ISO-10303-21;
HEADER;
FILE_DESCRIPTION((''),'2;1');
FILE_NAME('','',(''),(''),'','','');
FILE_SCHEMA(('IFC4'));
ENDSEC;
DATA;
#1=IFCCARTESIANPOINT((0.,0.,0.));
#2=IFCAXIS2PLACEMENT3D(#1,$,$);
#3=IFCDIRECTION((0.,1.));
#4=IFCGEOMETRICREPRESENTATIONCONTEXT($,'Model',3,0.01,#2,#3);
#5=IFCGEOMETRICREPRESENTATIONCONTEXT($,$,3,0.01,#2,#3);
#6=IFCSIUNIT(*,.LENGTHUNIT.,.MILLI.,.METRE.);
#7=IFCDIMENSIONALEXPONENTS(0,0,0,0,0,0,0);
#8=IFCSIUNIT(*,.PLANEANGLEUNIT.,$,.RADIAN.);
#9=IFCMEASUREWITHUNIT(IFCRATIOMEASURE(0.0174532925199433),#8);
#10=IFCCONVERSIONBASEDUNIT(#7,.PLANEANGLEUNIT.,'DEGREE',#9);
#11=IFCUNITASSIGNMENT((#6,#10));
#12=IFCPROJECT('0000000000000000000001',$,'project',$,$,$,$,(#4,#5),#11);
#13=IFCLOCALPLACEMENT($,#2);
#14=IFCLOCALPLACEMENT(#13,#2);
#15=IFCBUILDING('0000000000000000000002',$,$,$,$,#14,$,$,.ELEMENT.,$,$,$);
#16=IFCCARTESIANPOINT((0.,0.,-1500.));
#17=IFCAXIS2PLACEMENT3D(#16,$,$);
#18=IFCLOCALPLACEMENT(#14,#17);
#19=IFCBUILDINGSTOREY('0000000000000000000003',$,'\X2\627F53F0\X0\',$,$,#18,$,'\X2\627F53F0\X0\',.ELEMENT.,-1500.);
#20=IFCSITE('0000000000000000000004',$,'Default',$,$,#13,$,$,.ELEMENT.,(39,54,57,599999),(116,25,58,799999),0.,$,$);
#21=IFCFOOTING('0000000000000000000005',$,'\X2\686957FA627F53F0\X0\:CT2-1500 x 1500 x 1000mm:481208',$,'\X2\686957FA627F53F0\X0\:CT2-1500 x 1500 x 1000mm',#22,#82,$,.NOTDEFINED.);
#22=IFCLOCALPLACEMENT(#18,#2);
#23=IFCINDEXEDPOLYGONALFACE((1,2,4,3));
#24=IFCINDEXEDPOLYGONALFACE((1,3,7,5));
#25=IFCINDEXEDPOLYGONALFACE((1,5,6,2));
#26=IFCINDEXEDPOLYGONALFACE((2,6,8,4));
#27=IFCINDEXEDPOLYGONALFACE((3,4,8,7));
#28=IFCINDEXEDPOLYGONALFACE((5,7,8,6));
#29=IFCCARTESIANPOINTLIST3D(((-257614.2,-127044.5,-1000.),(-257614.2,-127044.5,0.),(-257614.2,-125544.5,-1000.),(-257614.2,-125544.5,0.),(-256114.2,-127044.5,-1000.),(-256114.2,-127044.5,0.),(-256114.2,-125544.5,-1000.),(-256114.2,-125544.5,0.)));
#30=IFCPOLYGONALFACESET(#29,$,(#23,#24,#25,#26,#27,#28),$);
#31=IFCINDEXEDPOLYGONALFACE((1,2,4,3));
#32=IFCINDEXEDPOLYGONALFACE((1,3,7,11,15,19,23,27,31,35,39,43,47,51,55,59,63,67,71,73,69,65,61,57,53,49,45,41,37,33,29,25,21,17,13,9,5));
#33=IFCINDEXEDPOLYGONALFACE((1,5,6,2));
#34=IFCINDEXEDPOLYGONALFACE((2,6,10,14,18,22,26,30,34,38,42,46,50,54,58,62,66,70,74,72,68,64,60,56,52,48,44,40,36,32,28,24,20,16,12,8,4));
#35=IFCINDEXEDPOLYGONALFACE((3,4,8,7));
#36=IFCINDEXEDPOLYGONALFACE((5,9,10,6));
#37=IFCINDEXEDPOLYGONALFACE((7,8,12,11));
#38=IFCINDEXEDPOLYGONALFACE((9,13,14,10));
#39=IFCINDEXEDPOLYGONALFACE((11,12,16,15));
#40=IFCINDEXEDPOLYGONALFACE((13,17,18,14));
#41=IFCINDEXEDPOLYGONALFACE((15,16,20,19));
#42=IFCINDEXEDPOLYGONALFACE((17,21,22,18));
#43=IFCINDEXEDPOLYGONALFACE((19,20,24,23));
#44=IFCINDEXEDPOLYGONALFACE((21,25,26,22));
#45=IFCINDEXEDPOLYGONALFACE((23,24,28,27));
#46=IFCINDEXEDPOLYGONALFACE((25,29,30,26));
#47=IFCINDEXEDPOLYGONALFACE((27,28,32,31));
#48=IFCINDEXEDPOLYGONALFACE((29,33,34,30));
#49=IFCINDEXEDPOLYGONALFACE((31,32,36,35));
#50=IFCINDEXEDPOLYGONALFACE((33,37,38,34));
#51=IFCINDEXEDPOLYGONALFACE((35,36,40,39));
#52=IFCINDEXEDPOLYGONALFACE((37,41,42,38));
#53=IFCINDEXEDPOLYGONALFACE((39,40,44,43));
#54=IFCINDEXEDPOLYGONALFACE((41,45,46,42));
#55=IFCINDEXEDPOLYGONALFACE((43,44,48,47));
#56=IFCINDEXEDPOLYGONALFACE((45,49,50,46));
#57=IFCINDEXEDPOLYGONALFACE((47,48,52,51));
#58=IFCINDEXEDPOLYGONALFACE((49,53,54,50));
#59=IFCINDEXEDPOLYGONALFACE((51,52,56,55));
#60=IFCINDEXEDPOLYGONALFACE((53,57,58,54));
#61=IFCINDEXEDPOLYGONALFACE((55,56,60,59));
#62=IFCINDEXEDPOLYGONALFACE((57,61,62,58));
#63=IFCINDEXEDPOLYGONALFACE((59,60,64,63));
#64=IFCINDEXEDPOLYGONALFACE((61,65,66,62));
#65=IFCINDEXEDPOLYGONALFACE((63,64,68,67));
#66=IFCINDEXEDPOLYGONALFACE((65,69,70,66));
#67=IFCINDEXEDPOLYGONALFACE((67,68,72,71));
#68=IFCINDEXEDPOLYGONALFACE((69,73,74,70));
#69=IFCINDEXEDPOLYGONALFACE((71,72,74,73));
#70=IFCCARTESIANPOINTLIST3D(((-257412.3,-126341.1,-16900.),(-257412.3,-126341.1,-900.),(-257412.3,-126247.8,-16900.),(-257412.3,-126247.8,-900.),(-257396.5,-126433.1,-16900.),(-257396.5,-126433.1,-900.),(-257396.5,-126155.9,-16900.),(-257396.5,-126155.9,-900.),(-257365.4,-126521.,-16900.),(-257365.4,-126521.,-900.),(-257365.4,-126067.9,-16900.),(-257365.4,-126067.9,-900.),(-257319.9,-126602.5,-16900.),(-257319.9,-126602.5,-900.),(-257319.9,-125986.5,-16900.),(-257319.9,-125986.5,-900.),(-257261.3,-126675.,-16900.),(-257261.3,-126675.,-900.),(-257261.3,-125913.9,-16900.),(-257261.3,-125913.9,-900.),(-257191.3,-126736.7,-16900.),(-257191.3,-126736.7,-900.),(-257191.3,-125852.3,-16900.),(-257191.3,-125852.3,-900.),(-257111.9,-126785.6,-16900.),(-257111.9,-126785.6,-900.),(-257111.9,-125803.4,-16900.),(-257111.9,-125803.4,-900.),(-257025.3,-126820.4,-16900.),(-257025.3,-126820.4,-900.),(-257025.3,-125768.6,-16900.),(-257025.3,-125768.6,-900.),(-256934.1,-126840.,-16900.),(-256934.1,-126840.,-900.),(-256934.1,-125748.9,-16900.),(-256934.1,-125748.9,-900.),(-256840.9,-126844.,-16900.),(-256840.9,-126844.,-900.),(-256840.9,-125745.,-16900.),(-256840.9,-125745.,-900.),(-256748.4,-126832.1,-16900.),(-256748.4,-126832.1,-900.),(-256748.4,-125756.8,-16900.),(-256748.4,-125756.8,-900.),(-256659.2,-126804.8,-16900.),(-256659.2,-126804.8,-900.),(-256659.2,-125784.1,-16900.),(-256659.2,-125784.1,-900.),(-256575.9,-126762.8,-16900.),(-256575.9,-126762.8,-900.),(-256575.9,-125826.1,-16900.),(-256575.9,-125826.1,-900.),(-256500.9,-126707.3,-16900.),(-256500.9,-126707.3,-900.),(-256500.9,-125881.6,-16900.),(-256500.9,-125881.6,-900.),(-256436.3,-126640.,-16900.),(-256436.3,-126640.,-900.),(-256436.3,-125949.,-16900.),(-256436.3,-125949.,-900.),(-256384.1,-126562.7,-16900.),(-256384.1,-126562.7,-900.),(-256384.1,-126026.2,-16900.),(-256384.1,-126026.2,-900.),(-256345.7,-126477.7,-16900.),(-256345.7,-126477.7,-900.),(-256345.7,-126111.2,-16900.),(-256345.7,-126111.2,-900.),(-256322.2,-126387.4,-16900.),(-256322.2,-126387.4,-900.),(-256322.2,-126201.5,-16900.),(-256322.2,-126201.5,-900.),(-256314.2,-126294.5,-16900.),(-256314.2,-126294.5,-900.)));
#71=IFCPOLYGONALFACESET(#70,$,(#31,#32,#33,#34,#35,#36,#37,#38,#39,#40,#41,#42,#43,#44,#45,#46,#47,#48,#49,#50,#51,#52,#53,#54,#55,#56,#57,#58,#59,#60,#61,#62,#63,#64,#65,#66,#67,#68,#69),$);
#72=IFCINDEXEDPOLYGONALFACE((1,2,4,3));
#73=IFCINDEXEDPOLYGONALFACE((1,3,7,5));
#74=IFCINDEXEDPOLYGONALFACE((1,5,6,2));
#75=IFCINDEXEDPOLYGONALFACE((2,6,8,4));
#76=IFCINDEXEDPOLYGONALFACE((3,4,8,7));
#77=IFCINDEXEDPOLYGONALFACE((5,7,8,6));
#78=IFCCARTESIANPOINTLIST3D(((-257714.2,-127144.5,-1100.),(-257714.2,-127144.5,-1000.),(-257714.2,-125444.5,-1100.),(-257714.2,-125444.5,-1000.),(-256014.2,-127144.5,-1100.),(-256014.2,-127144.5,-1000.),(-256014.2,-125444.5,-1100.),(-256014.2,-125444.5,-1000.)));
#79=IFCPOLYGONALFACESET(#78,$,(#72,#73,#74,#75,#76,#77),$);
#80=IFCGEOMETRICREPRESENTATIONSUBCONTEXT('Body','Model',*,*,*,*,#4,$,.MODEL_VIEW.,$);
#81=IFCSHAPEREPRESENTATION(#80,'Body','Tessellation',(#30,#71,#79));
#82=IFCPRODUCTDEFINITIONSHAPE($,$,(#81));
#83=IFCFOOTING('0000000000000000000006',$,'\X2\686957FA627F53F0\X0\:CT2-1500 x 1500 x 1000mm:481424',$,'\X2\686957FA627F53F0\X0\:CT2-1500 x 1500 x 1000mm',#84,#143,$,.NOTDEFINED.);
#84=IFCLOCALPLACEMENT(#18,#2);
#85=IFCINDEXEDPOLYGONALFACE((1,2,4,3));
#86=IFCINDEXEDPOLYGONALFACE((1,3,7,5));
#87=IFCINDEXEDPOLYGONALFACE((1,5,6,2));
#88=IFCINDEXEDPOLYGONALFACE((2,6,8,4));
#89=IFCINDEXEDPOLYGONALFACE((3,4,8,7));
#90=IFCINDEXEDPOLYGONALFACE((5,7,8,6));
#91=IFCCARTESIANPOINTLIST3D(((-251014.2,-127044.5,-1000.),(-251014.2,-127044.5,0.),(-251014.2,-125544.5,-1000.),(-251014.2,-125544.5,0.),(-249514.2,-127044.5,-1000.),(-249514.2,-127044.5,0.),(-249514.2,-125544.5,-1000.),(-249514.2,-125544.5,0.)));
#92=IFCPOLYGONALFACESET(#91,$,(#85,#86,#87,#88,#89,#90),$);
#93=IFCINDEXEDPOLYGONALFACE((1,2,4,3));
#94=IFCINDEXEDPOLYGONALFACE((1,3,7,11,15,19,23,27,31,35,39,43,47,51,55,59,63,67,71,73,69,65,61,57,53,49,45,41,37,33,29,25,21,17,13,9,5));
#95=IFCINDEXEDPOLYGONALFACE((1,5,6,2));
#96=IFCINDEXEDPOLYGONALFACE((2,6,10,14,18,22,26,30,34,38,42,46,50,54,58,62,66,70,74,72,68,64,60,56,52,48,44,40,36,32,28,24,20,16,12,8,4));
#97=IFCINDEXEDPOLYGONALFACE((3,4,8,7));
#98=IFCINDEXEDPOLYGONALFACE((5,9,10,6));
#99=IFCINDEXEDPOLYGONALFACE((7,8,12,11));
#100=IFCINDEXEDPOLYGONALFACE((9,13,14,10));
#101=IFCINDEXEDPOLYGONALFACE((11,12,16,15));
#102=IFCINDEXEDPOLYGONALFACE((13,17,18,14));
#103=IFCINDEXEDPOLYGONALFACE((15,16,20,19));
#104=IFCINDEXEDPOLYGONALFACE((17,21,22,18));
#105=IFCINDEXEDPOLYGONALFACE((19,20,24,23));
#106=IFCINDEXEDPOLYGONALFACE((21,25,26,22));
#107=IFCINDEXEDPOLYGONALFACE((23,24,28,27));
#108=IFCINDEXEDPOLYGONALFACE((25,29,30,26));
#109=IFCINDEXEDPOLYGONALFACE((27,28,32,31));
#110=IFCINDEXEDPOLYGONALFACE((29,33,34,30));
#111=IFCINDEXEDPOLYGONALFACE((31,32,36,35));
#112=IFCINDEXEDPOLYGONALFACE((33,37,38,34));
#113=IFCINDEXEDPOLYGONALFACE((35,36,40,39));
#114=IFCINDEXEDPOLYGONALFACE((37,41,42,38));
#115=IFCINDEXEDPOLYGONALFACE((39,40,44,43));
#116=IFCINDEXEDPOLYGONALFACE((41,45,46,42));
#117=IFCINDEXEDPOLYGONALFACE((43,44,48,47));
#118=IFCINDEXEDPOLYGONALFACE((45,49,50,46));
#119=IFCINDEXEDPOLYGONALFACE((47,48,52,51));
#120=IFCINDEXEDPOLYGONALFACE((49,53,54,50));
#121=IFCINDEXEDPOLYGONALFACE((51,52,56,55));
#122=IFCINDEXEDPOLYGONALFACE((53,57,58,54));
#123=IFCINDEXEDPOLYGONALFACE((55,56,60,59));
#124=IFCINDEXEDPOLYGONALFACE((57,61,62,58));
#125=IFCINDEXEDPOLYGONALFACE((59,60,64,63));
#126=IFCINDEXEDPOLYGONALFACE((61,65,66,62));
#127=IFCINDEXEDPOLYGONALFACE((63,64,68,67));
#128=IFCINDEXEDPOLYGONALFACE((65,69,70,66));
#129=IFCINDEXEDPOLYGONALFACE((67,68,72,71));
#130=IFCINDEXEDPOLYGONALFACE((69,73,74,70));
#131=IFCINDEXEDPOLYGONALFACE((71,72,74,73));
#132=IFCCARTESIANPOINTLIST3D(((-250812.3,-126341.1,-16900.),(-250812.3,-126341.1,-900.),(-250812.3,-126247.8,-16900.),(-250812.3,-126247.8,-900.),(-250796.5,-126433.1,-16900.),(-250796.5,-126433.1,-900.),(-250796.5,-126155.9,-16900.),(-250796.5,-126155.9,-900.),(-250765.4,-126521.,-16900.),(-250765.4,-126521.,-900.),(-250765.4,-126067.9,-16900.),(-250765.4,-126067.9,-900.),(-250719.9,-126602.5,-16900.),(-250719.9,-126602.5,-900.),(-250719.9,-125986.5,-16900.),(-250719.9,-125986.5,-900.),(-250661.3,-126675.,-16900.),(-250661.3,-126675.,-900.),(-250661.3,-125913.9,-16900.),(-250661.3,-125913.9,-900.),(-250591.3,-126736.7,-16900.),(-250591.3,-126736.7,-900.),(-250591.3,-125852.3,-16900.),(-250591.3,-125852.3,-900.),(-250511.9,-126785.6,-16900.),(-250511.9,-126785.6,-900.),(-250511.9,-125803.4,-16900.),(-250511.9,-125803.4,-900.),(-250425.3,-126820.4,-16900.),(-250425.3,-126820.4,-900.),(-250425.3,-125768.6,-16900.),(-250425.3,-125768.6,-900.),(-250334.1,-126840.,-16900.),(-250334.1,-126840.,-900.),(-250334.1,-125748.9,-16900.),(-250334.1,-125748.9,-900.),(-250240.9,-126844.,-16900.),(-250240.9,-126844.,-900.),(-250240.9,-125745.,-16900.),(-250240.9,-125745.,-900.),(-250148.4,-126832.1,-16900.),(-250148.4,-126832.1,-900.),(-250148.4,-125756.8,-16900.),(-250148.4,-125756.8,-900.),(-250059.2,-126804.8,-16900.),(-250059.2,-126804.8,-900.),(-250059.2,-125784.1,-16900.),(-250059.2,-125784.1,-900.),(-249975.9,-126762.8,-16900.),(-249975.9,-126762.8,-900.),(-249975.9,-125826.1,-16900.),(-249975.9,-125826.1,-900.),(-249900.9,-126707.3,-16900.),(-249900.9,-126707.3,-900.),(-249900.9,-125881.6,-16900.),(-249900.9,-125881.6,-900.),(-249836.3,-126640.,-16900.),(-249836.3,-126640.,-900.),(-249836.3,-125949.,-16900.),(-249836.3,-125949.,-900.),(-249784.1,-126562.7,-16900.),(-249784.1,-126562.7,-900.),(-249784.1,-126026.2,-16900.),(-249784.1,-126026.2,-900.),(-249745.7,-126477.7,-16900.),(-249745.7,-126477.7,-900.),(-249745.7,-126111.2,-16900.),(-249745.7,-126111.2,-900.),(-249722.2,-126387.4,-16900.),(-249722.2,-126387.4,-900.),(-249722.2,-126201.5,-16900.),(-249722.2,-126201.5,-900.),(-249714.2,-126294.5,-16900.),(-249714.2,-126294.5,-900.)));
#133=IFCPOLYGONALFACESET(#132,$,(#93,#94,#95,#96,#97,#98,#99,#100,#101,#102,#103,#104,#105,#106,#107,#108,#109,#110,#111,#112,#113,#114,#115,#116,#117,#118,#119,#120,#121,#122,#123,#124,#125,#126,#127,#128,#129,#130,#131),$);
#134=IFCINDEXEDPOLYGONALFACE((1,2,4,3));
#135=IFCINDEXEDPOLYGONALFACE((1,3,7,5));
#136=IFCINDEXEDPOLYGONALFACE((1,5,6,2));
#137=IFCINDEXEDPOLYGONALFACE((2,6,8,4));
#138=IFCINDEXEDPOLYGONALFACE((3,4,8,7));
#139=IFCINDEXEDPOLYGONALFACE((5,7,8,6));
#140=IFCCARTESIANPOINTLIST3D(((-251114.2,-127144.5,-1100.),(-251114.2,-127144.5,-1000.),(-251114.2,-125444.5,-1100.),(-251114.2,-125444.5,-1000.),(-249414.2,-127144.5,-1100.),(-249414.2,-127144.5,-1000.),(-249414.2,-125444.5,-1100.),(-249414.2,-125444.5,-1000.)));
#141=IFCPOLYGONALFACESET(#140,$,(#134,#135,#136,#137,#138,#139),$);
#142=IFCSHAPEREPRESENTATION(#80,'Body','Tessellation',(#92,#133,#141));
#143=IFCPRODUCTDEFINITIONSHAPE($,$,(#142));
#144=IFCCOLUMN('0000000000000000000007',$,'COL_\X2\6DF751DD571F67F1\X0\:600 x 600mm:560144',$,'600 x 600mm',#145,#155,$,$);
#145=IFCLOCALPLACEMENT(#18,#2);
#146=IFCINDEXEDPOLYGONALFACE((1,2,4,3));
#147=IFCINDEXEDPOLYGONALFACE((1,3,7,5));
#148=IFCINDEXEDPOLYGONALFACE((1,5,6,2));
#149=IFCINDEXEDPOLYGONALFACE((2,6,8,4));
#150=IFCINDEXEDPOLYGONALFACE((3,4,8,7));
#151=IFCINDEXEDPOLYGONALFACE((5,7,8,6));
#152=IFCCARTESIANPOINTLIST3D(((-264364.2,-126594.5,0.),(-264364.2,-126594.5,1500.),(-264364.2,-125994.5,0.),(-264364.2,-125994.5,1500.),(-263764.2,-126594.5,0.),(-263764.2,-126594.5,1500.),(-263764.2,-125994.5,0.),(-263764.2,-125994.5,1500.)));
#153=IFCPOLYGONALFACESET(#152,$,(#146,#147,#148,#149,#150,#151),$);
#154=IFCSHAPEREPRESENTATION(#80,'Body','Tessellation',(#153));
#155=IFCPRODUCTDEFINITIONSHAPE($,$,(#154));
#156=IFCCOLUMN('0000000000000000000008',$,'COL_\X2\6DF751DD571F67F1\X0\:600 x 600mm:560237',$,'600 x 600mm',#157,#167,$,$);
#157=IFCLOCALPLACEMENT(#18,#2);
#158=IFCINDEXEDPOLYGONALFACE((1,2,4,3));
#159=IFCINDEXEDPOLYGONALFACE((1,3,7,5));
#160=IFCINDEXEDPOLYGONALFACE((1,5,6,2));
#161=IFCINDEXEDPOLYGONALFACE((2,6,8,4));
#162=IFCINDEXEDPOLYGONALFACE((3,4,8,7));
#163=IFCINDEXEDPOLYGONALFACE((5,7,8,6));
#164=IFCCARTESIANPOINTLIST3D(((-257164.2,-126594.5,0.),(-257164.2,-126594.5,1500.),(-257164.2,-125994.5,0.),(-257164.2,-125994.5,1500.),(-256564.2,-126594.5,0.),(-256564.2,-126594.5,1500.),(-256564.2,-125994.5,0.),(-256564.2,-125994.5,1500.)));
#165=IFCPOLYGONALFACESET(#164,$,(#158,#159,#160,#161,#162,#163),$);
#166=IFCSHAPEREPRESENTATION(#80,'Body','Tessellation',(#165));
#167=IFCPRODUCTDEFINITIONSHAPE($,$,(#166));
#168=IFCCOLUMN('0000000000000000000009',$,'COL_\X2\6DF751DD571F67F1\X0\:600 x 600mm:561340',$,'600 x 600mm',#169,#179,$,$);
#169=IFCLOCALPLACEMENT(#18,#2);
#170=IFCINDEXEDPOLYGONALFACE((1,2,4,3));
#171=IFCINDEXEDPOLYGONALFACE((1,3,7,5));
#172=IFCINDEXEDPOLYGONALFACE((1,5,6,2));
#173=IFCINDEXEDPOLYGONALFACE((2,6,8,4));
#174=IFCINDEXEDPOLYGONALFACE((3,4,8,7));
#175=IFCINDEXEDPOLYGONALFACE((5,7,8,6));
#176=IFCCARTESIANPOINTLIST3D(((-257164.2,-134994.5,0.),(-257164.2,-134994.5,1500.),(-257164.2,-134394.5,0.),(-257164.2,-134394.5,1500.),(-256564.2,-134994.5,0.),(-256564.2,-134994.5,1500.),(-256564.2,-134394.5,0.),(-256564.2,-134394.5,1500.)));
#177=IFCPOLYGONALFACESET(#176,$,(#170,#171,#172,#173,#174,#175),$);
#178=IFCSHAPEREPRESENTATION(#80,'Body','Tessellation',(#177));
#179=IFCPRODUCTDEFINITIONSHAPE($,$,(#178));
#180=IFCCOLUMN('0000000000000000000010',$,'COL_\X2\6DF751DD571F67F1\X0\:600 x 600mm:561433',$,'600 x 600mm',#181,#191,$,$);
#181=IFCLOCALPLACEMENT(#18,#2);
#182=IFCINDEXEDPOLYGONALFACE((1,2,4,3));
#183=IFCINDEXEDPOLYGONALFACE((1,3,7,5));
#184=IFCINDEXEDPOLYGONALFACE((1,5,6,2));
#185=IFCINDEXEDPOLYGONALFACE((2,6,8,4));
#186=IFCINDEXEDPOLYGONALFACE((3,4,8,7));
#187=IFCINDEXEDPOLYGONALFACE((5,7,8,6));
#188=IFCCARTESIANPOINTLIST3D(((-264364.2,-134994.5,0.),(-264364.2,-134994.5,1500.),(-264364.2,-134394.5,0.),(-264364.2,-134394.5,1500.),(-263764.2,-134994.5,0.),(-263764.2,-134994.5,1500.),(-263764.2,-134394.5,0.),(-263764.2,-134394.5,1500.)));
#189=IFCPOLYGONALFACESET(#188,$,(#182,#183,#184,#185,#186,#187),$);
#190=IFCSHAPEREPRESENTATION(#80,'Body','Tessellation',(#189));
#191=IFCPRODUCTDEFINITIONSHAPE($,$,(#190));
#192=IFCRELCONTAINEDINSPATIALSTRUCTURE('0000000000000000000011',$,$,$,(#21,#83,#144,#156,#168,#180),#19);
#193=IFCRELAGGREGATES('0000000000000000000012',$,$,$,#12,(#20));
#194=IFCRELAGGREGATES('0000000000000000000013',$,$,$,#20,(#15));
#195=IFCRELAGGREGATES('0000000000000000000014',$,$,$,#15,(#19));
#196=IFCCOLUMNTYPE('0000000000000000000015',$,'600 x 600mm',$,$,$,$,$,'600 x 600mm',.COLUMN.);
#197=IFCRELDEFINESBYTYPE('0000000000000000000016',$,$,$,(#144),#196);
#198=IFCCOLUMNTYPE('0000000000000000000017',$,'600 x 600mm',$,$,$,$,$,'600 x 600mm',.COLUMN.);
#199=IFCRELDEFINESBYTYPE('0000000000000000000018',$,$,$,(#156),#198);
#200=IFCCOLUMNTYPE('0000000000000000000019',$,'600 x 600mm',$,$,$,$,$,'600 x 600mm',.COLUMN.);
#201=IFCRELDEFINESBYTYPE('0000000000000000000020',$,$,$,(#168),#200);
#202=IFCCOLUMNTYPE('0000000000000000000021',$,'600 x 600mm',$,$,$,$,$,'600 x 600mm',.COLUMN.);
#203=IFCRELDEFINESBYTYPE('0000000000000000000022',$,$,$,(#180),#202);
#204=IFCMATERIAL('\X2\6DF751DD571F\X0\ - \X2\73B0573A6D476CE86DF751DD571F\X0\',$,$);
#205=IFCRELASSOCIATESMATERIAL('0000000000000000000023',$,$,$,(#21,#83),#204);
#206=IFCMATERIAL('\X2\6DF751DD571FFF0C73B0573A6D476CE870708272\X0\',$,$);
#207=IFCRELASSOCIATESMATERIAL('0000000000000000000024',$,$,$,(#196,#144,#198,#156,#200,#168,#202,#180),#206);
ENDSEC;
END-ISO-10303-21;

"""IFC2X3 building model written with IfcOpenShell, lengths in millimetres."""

from ifc_helpers import new_model, entity, si_unit, converted_unit, direction, frame, frame_2d, origin, origin_2d_with_axis, place, context, subcontext, project, spatial, rectangle, circle, extrude, source, transform, mapped, material, type_object, type_shapes, element, save


model = new_model("IFC2X3")

# Units and contexts
model_context = context("Model", 3, precision=0.01, world=origin(), true_north=direction((0.0, 1.0)))
context_of_model = context(None, 3, precision=0.01, world=origin(), true_north=direction((0.0, 1.0)))
body_context = subcontext(model_context, "Body", "Model", "MODEL_VIEW")
ifc_project = project(units=[si_unit("LENGTHUNIT", "METRE", prefix="MILLI"), converted_unit("PLANEANGLEUNIT", "DEGREE", entity("IfcRatioMeasure", 0.0174532925199433), si_unit("PLANEANGLEUNIT", "RADIAN"), dimensions=[0, 0, 0, 0, 0, 0, 0])], contexts=[model_context, context_of_model])

# Site, building, storey
site_placement = place(None, origin())
site = spatial("IfcSite", under=ifc_project, at=site_placement, Name="Default", CompositionType="ELEMENT", RefLatitude=(39, 54, 57, 599999), RefLongitude=(116, 25, 58, 799999), RefElevation=0.0)
building_placement = place(site_placement, origin())
building = spatial("IfcBuilding", under=site, at=building_placement, CompositionType="ELEMENT")
storey_placement = place(building_placement, frame((0.0, 0.0, -1500.0)))
storey = spatial("IfcBuildingStorey", under=building, at=storey_placement, Name="承台", LongName="承台", CompositionType="ELEMENT", Elevation=-1500.0)

# Footings
ifc_material_1 = material(Name="混凝土 - 现场浇注混凝土")
footing_1_placement = place(storey_placement, frame((-257714.2, -127144.5, -16900.0)))
element("IfcFooting", 1, at=footing_1_placement, inside=storey, material=ifc_material_1, Name="桩基承台:CT2-1500 x 1500 x 1000mm:481208", ObjectType="桩基承台:CT2-1500 x 1500 x 1000mm", PredefinedType="NOTDEFINED", context=body_context, shape_type="SweptSolid", body=[
    extrude(rectangle(XDim=1500.0, YDim=1500.0, at=origin_2d_with_axis()), frame((850.0, 850.0, 15900.0), z_axis=(0.0, 0.0, 1.0), x_axis=(-1.0, 0.0, 0.0)), (0.0, 0.0, 1.0), 1000.0),
    extrude(circle(Radius=550.0, at=origin_2d_with_axis()), frame((850.0, 850.0, 0.0)), (0.0, 0.0, 1.0), 16000.0),
    extrude(rectangle(XDim=1700.0, YDim=1700.0, at=frame_2d((0.0, 0.0), x_axis=(1.0, 0.0))), frame((850.0, 850.0, 15800.0), z_axis=(0.0, 0.0, 1.0), x_axis=(0.0, 1.0, 0.0)), (0.0, 0.0, 1.0), 100.0),
])
footing_2_placement = place(storey_placement, frame((-251114.2, -127144.5, -16900.0)))
element("IfcFooting", 2, at=footing_2_placement, inside=storey, material=ifc_material_1, Name="桩基承台:CT2-1500 x 1500 x 1000mm:481424", ObjectType="桩基承台:CT2-1500 x 1500 x 1000mm", PredefinedType="NOTDEFINED", context=body_context, shape_type="SweptSolid", body=[
    extrude(rectangle(XDim=1500.0, YDim=1500.0, at=origin_2d_with_axis()), frame((850.0, 850.0, 15900.0), z_axis=(0.0, 0.0, 1.0), x_axis=(-1.0, 0.0, 0.0)), (0.0, 0.0, 1.0), 1000.0),
    extrude(circle(Radius=550.0, at=origin_2d_with_axis()), frame((850.0, 850.0, 0.0)), (0.0, 0.0, 1.0), 16000.0),
    extrude(rectangle(XDim=1700.0, YDim=1700.0, at=frame_2d((0.0, 0.0), x_axis=(1.0, 0.0))), frame((850.0, 850.0, 15800.0), z_axis=(0.0, 0.0, 1.0), x_axis=(0.0, 1.0, 0.0)), (0.0, 0.0, 1.0), 100.0),
])

# Columns
ifc_material_2 = material(Name="混凝土，现场浇注灰色")
column_type_1 = type_object("IfcColumnType", Name="600 x 600mm", ElementType="600 x 600mm", PredefinedType="COLUMN", material=ifc_material_2)
shared_shape_1 = source(origin(), body_context, "Body", "SweptSolid", [
    extrude(rectangle(XDim=600.0, YDim=600.0, at=origin_2d_with_axis()), frame((300.0, 300.0, 0.0), z_axis=(0.0, 0.0, 1.0), x_axis=(-1.0, 0.0, 0.0)), (0.0, 0.0, 1.0), 1500.0),
])
type_shapes(column_type_1, [shared_shape_1])
column_1_placement = place(storey_placement, frame((-264364.2, -126594.5, 0.0)))
element("IfcColumn", 3, at=column_1_placement, inside=storey, type_object=column_type_1, material=ifc_material_2, Name="COL_混凝土柱:600 x 600mm:560144", ObjectType="600 x 600mm", context=body_context, shape_type="MappedRepresentation", body=[
    mapped(shared_shape_1, transform((0.0, 0.0, 0.0), scale=1.0)),
])
column_type_2 = type_object("IfcColumnType", Name="600 x 600mm", ElementType="600 x 600mm", PredefinedType="COLUMN", material=ifc_material_2)
shared_shape_2 = source(origin(), body_context, "Body", "SweptSolid", [
    extrude(rectangle(XDim=600.0, YDim=600.0, at=origin_2d_with_axis()), frame((300.0, 300.0, 0.0), z_axis=(0.0, 0.0, 1.0), x_axis=(-1.0, 0.0, 0.0)), (0.0, 0.0, 1.0), 1500.0),
])
type_shapes(column_type_2, [shared_shape_2])
column_2_placement = place(storey_placement, frame((-257164.2, -126594.5, 0.0)))
element("IfcColumn", 4, at=column_2_placement, inside=storey, type_object=column_type_2, material=ifc_material_2, Name="COL_混凝土柱:600 x 600mm:560237", ObjectType="600 x 600mm", context=body_context, shape_type="MappedRepresentation", body=[
    mapped(shared_shape_2, transform((0.0, 0.0, 0.0), scale=1.0)),
])
column_type_3 = type_object("IfcColumnType", Name="600 x 600mm", ElementType="600 x 600mm", PredefinedType="COLUMN", material=ifc_material_2)
shared_shape_3 = source(origin(), body_context, "Body", "SweptSolid", [
    extrude(rectangle(XDim=600.0, YDim=600.0, at=origin_2d_with_axis()), frame((300.0, 300.0, 0.0), z_axis=(0.0, 0.0, 1.0), x_axis=(-1.0, 0.0, 0.0)), (0.0, 0.0, 1.0), 1500.0),
])
type_shapes(column_type_3, [shared_shape_3])
column_3_placement = place(storey_placement, frame((-257164.2, -134994.5, 0.0)))
element("IfcColumn", 5, at=column_3_placement, inside=storey, type_object=column_type_3, material=ifc_material_2, Name="COL_混凝土柱:600 x 600mm:561340", ObjectType="600 x 600mm", context=body_context, shape_type="MappedRepresentation", body=[
    mapped(shared_shape_3, transform((0.0, 0.0, 0.0), scale=1.0)),
])
column_type_4 = type_object("IfcColumnType", Name="600 x 600mm", ElementType="600 x 600mm", PredefinedType="COLUMN", material=ifc_material_2)
shared_shape_4 = source(origin(), body_context, "Body", "SweptSolid", [
    extrude(rectangle(XDim=600.0, YDim=600.0, at=origin_2d_with_axis()), frame((300.0, 300.0, 0.0), z_axis=(0.0, 0.0, 1.0), x_axis=(-1.0, 0.0, 0.0)), (0.0, 0.0, 1.0), 1500.0),
])
type_shapes(column_type_4, [shared_shape_4])
column_4_placement = place(storey_placement, frame((-264364.2, -134994.5, 0.0)))
element("IfcColumn", 6, at=column_4_placement, inside=storey, type_object=column_type_4, material=ifc_material_2, Name="COL_混凝土柱:600 x 600mm:561433", ObjectType="600 x 600mm", context=body_context, shape_type="MappedRepresentation", body=[
    mapped(shared_shape_4, transform((0.0, 0.0, 0.0), scale=1.0)),
])

save(model, "model.ifc")
